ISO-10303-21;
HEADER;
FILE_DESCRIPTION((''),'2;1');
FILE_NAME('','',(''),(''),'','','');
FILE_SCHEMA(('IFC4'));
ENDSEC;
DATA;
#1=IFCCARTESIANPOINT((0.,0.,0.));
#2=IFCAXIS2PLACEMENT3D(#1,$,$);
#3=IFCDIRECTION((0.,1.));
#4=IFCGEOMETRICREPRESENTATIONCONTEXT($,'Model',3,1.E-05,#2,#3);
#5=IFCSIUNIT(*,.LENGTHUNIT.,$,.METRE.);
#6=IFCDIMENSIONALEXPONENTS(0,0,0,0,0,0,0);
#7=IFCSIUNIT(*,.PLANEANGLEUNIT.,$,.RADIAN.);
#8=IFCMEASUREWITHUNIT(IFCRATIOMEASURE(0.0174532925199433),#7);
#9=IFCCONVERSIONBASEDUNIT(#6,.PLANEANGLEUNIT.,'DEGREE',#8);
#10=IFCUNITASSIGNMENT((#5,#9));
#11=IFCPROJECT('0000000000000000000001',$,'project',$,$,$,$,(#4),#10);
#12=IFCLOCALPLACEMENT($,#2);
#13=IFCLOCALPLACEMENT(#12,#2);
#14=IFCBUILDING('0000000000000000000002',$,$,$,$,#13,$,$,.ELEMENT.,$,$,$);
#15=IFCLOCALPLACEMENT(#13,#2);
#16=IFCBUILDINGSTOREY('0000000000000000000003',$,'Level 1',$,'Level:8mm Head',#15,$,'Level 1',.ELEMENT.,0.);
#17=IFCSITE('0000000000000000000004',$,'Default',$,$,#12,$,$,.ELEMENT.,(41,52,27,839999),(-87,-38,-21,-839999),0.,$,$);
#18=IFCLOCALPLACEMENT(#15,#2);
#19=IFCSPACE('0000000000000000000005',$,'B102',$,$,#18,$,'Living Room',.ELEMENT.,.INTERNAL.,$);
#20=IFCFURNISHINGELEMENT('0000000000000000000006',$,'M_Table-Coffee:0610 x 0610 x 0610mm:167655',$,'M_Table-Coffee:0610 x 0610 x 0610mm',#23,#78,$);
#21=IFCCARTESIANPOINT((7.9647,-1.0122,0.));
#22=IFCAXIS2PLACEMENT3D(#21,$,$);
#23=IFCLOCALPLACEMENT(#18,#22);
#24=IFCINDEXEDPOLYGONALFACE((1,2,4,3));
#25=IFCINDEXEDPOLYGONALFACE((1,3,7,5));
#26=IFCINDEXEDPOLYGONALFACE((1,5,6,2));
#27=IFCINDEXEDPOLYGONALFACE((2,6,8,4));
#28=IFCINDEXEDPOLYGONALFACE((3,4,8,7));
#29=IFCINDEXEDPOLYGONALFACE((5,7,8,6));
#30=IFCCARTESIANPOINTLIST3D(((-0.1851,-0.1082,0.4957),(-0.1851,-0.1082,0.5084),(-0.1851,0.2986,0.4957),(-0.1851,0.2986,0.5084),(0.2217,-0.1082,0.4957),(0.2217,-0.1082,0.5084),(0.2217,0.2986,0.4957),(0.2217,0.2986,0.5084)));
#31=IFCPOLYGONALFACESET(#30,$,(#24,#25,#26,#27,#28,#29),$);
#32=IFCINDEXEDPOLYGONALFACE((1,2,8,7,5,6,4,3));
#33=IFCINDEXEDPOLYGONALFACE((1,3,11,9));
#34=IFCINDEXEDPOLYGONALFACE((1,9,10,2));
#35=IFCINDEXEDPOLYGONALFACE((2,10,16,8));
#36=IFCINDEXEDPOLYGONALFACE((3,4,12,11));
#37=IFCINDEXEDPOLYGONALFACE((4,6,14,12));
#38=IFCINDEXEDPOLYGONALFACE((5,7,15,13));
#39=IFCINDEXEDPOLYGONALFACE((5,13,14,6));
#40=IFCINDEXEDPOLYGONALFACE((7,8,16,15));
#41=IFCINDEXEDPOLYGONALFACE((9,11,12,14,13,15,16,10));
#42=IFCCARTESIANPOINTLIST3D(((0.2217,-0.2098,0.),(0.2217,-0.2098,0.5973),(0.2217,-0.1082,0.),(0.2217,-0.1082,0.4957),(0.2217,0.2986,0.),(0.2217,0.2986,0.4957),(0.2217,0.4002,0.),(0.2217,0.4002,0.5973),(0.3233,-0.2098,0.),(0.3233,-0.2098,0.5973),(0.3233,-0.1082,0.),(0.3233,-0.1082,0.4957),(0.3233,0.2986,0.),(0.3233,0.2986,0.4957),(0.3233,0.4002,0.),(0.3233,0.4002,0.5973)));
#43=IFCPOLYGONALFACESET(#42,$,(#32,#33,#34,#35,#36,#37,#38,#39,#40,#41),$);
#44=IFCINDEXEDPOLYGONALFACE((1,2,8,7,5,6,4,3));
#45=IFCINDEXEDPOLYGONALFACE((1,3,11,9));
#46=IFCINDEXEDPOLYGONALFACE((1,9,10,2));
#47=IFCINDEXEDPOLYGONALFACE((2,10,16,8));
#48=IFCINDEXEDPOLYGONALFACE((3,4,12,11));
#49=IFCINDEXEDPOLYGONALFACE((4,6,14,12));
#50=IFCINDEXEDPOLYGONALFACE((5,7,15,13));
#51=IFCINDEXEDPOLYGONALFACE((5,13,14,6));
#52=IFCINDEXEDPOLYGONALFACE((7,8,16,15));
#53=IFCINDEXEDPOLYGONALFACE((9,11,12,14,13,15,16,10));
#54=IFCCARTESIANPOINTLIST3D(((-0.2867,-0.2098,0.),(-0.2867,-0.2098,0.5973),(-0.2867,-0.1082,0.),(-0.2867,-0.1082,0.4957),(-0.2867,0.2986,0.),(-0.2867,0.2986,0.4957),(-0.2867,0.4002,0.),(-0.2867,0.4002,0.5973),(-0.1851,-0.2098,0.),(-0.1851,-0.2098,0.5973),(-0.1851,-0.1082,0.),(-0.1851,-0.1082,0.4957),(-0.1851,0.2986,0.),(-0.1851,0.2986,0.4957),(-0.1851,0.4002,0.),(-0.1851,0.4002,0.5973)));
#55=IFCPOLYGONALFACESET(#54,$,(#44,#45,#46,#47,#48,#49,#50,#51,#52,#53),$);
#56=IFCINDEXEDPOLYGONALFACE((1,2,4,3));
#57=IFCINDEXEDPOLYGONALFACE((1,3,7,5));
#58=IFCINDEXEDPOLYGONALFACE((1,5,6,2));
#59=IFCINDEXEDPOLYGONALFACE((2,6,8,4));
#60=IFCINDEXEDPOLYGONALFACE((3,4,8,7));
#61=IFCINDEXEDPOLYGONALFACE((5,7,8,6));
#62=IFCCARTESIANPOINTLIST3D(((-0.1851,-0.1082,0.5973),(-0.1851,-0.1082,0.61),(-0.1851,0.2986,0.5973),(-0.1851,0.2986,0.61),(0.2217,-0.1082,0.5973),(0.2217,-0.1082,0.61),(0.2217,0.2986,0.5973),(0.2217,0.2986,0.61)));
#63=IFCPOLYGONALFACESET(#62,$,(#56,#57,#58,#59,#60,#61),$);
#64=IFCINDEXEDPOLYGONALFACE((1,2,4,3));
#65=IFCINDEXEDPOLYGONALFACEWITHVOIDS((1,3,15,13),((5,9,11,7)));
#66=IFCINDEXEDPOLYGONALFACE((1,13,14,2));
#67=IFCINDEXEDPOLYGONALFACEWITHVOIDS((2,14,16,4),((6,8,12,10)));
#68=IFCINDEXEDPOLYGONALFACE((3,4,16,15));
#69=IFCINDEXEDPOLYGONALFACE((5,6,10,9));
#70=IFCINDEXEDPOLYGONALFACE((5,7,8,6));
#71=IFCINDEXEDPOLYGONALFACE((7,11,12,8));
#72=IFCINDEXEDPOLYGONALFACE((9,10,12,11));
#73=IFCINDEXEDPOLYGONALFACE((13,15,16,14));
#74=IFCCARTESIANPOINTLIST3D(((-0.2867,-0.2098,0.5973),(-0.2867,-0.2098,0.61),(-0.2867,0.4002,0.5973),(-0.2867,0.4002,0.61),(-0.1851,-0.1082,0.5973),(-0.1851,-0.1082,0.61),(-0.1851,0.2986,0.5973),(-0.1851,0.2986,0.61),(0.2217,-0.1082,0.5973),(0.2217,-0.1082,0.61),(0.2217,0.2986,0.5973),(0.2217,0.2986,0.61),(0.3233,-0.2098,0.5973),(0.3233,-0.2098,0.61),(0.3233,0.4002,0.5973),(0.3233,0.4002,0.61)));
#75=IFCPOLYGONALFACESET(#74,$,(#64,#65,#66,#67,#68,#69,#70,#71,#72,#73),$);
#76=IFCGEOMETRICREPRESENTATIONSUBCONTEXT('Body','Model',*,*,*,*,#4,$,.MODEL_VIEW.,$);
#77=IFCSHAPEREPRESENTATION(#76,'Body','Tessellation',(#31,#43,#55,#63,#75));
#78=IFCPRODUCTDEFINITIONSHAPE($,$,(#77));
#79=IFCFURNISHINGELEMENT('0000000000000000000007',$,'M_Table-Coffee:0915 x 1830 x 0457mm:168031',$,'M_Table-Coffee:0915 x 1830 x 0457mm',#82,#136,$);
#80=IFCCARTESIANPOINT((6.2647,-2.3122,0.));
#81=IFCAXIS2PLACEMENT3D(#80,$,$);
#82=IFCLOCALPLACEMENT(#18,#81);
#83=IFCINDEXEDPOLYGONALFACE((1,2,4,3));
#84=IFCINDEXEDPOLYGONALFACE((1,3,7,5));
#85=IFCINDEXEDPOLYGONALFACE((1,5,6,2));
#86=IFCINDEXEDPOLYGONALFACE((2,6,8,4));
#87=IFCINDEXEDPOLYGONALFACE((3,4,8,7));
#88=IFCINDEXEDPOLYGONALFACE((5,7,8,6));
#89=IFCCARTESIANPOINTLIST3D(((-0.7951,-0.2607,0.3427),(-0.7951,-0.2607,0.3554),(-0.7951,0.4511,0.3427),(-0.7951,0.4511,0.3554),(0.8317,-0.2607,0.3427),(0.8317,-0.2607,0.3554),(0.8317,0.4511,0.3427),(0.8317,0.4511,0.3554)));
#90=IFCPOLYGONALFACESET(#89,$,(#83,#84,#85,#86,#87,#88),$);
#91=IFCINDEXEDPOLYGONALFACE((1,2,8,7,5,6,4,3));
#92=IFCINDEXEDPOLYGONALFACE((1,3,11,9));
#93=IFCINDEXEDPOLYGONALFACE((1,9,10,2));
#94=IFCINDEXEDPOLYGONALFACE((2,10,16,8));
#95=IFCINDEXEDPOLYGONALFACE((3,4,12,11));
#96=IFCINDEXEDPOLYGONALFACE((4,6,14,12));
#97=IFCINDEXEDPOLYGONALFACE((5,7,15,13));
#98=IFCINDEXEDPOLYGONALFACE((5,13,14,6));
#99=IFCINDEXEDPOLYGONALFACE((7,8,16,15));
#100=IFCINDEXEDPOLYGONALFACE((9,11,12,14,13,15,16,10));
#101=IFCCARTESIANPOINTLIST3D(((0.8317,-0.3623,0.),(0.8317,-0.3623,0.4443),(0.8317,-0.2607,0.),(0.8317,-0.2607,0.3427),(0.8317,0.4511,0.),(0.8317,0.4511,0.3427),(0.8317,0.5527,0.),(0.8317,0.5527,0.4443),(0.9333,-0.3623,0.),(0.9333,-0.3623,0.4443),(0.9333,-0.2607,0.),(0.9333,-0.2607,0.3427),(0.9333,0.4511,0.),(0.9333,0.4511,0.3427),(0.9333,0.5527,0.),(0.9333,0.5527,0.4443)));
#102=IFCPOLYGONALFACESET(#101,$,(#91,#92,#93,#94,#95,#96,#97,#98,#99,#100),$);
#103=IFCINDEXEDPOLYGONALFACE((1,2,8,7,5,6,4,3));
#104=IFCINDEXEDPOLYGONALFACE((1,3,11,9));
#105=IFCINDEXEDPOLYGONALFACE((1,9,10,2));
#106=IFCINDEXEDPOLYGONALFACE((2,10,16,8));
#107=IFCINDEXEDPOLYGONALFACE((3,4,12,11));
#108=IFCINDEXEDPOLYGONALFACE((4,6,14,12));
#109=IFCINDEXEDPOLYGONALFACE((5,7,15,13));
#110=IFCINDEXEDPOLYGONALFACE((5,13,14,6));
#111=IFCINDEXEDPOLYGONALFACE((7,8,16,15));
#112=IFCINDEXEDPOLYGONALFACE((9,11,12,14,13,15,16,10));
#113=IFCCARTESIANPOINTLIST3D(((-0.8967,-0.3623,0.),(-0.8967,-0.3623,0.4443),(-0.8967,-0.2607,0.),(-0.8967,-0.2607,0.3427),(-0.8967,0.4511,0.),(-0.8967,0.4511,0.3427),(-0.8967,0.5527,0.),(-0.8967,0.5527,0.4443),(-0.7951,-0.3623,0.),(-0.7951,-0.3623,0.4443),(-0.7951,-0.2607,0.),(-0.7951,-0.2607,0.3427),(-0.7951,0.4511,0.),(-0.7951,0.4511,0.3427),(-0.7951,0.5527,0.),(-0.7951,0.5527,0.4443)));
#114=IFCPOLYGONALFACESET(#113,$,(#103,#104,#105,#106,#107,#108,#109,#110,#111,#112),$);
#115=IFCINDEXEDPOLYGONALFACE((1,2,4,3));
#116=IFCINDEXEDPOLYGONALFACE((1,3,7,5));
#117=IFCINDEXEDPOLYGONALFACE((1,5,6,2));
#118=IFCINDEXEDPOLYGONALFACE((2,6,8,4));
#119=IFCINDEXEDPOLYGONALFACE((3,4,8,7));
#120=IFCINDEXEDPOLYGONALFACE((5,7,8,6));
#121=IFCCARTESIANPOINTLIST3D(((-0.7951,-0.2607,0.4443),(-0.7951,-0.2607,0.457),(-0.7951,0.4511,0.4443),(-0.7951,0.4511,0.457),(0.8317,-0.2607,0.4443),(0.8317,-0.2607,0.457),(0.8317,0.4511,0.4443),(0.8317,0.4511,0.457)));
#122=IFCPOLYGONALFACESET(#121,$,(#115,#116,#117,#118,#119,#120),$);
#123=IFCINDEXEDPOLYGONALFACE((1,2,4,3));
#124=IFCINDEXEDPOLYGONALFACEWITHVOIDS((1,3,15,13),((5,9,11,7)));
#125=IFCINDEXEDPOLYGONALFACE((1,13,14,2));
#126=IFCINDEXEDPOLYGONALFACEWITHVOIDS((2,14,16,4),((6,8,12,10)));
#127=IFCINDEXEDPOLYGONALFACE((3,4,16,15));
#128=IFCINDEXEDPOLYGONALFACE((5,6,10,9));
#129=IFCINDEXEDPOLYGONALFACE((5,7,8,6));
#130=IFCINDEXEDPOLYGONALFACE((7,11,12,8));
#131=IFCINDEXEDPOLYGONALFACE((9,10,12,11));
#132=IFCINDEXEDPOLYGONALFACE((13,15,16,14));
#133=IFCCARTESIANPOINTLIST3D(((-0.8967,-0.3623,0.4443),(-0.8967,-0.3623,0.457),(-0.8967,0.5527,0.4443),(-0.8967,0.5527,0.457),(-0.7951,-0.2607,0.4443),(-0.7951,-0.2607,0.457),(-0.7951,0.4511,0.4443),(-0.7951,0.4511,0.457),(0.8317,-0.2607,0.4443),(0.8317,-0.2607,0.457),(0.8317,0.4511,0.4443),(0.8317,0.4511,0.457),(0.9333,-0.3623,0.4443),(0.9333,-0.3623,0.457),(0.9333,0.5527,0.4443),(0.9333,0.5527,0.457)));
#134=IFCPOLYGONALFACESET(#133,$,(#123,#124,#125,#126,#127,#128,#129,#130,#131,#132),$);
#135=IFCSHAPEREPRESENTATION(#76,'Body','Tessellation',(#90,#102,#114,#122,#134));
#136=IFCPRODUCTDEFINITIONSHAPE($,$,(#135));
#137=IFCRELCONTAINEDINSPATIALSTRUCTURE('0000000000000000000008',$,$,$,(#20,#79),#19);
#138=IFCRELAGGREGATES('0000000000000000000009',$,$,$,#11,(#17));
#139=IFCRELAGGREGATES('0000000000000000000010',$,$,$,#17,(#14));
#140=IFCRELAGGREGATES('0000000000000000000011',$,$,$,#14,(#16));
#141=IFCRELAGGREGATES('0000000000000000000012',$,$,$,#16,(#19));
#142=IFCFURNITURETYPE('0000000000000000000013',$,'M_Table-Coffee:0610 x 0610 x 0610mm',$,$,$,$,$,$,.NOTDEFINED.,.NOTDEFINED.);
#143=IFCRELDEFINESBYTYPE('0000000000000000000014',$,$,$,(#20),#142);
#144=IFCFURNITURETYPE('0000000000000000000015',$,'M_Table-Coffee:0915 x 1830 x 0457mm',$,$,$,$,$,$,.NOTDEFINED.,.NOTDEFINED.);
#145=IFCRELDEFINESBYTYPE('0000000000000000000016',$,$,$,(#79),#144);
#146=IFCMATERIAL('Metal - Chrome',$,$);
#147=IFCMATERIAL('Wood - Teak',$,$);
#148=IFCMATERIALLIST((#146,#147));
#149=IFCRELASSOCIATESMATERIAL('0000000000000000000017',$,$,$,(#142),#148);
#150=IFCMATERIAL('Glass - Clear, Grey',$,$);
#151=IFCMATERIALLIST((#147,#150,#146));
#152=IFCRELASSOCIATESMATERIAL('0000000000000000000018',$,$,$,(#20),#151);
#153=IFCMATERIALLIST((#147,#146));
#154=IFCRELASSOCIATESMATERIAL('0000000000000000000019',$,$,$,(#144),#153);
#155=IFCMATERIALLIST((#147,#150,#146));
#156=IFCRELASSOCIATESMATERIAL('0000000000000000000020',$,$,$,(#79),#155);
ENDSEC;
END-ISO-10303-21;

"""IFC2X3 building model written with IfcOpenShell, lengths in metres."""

from ifc_helpers import new_model, entity, si_unit, converted_unit, direction, frame, origin, origin_2d_with_axis, place, context, subcontext, project, spatial, polyline, rectangle, outline, extrude, source, transform, mapped, material, material_list, type_object, type_shapes, element, save


model = new_model("IFC2X3")

# Units and contexts
model_context = context("Model", 3, precision=1e-05, world=origin(), true_north=direction((0.0, 1.0)))
body_context = subcontext(model_context, "Body", "Model", "MODEL_VIEW")
ifc_project = project(units=[si_unit("LENGTHUNIT", "METRE"), converted_unit("PLANEANGLEUNIT", "DEGREE", entity("IfcRatioMeasure", 0.0174532925199433), si_unit("PLANEANGLEUNIT", "RADIAN"), dimensions=[0, 0, 0, 0, 0, 0, 0])], contexts=[model_context])

# Site, building, storey
site_placement = place(None, origin())
site = spatial("IfcSite", under=ifc_project, at=site_placement, Name="Default", CompositionType="ELEMENT", RefLatitude=(41, 52, 27, 839999), RefLongitude=(-87, -38, -21, -839999), RefElevation=0.0)
building_placement = place(site_placement, origin())
building = spatial("IfcBuilding", under=site, at=building_placement, CompositionType="ELEMENT")
storey_placement = place(building_placement, origin())
storey = spatial("IfcBuildingStorey", under=building, at=storey_placement, Name="Level 1", ObjectType="Level:8mm Head", LongName="Level 1", CompositionType="ELEMENT", Elevation=0.0)

# Shared definitions
space_1_placement = place(storey_placement, origin())
space_1 = spatial("IfcSpace", under=storey, at=space_1_placement, Name="B102", LongName="Living Room", CompositionType="ELEMENT", InteriorOrExteriorSpace="INTERNAL")

# Furnishing elements
ifc_material_1 = material(Name="Wood - Teak")
ifc_material_2 = material(Name="Glass - Clear, Grey")
ifc_material_3 = material(Name="Metal - Chrome")
ifc_material_list_1 = material_list([ifc_material_1, ifc_material_2, ifc_material_3])
ifc_material_list_2 = material_list([ifc_material_3, ifc_material_1])
furniture_type_1 = type_object("IfcFurnitureType", Name="M_Table-Coffee:0610 x 0610 x 0610mm", material=ifc_material_list_2)
shared_shape_1 = source(origin(), body_context, "Body", "SweptSolid", [
    extrude(rectangle(XDim=0.4068, YDim=0.4068, at=origin_2d_with_axis()), frame((0.0183, 0.0952, 0.4957), z_axis=(0.0, 0.0, 1.0), x_axis=(-1.0, 0.0, 0.0)), (0.0, 0.0, 1.0), 0.0127),
    extrude(outline(polyline([(-0.2732, -0.305), (0.324, -0.305), (0.324, 0.305), (-0.2732, 0.305), (-0.2732, 0.2034), (0.2225, 0.2034), (0.2225, -0.2034), (-0.2732, -0.2034), (-0.2732, -0.305)])), frame((0.2217, 0.0952, 0.2732), z_axis=(1.0, 0.0, 0.0), x_axis=(0.0, 0.0, 1.0)), (0.0, 0.0, 1.0), 0.1016),
    extrude(outline(polyline([(-0.305, -0.3241), (0.305, -0.3241), (0.305, 0.2733), (0.2034, 0.2733), (0.2034, -0.2224), (-0.2034, -0.2224), (-0.2034, 0.2733), (-0.305, 0.2733), (-0.305, -0.3241)])), frame((-0.2867, 0.0952, 0.2733), z_axis=(1.0, 0.0, 0.0), x_axis=(0.0, -1.0, 0.0)), (0.0, 0.0, 1.0), 0.1016),
    extrude(rectangle(XDim=0.4068, YDim=0.4068, at=origin_2d_with_axis()), frame((0.0183, 0.0952, 0.5973), z_axis=(0.0, 0.0, 1.0), x_axis=(-1.0, 0.0, 0.0)), (0.0, 0.0, 1.0), 0.0127),
    extrude(outline(polyline([(-0.305, -0.305), (0.305, -0.305), (0.305, 0.305), (-0.305, 0.305), (-0.305, -0.305)]), holes=[polyline([(-0.2034, -0.2034), (-0.2034, 0.2034), (0.2034, 0.2034), (0.2034, -0.2034), (-0.2034, -0.2034)])]), frame((0.0183, 0.0952, 0.5973), z_axis=(0.0, 0.0, 1.0), x_axis=(-1.0, 0.0, 0.0)), (0.0, 0.0, 1.0), 0.0127),
])
type_shapes(furniture_type_1, [shared_shape_1])
furnishing_1_placement = place(space_1_placement, frame((7.9647, -1.0122, 0.0)))
element("IfcFurnishingElement", 1, at=furnishing_1_placement, inside=space_1, type_object=furniture_type_1, material=ifc_material_list_1, Name="M_Table-Coffee:0610 x 0610 x 0610mm:167655", ObjectType="M_Table-Coffee:0610 x 0610 x 0610mm", context=body_context, shape_type="MappedRepresentation", body=[
    mapped(shared_shape_1, transform((0.0, 0.0, 0.0), scale=1.0)),
])
ifc_material_list_3 = material_list([ifc_material_1, ifc_material_2, ifc_material_3])
ifc_material_list_4 = material_list([ifc_material_1, ifc_material_3])
furniture_type_2 = type_object("IfcFurnitureType", Name="M_Table-Coffee:0915 x 1830 x 0457mm", material=ifc_material_list_4)
shared_shape_2 = source(origin(), body_context, "Body", "SweptSolid", [
    extrude(rectangle(XDim=1.6268, YDim=0.7118, at=origin_2d_with_axis()), frame((0.0183, 0.0952, 0.3427), z_axis=(0.0, 0.0, 1.0), x_axis=(-1.0, 0.0, 0.0)), (0.0, 0.0, 1.0), 0.0127),
    extrude(outline(polyline([(-0.1967, -0.4575), (0.2475, -0.4575), (0.2475, 0.4575), (-0.1967, 0.4575), (-0.1967, 0.3559), (0.146, 0.3559), (0.146, -0.3559), (-0.1967, -0.3559), (-0.1967, -0.4575)])), frame((0.8317, 0.0952, 0.1967), z_axis=(1.0, 0.0, 0.0), x_axis=(0.0, 0.0, 1.0)), (0.0, 0.0, 1.0), 0.1016),
    extrude(outline(polyline([(-0.4575, -0.2476), (0.4575, -0.2476), (0.4575, 0.1968), (0.3559, 0.1968), (0.3559, -0.1459), (-0.3559, -0.1459), (-0.3559, 0.1968), (-0.4575, 0.1968), (-0.4575, -0.2476)])), frame((-0.8967, 0.0952, 0.1968), z_axis=(1.0, 0.0, 0.0), x_axis=(0.0, -1.0, 0.0)), (0.0, 0.0, 1.0), 0.1016),
    extrude(rectangle(XDim=1.6268, YDim=0.7118, at=origin_2d_with_axis()), frame((0.0183, 0.0952, 0.4443), z_axis=(0.0, 0.0, 1.0), x_axis=(-1.0, 0.0, 0.0)), (0.0, 0.0, 1.0), 0.0127),
    extrude(outline(polyline([(-0.915, -0.4575), (0.915, -0.4575), (0.915, 0.4575), (-0.915, 0.4575), (-0.915, -0.4575)]), holes=[polyline([(-0.8134, -0.3559), (-0.8134, 0.3559), (0.8134, 0.3559), (0.8134, -0.3559), (-0.8134, -0.3559)])]), frame((0.0183, 0.0952, 0.4443), z_axis=(0.0, 0.0, 1.0), x_axis=(-1.0, 0.0, 0.0)), (0.0, 0.0, 1.0), 0.0127),
])
type_shapes(furniture_type_2, [shared_shape_2])
furnishing_2_placement = place(space_1_placement, frame((6.2647, -2.3122, 0.0)))
element("IfcFurnishingElement", 2, at=furnishing_2_placement, inside=space_1, type_object=furniture_type_2, material=ifc_material_list_3, Name="M_Table-Coffee:0915 x 1830 x 0457mm:168031", ObjectType="M_Table-Coffee:0915 x 1830 x 0457mm", context=body_context, shape_type="MappedRepresentation", body=[
    mapped(shared_shape_2, transform((0.0, 0.0, 0.0), scale=1.0)),
])

save(model, "model.ifc")
